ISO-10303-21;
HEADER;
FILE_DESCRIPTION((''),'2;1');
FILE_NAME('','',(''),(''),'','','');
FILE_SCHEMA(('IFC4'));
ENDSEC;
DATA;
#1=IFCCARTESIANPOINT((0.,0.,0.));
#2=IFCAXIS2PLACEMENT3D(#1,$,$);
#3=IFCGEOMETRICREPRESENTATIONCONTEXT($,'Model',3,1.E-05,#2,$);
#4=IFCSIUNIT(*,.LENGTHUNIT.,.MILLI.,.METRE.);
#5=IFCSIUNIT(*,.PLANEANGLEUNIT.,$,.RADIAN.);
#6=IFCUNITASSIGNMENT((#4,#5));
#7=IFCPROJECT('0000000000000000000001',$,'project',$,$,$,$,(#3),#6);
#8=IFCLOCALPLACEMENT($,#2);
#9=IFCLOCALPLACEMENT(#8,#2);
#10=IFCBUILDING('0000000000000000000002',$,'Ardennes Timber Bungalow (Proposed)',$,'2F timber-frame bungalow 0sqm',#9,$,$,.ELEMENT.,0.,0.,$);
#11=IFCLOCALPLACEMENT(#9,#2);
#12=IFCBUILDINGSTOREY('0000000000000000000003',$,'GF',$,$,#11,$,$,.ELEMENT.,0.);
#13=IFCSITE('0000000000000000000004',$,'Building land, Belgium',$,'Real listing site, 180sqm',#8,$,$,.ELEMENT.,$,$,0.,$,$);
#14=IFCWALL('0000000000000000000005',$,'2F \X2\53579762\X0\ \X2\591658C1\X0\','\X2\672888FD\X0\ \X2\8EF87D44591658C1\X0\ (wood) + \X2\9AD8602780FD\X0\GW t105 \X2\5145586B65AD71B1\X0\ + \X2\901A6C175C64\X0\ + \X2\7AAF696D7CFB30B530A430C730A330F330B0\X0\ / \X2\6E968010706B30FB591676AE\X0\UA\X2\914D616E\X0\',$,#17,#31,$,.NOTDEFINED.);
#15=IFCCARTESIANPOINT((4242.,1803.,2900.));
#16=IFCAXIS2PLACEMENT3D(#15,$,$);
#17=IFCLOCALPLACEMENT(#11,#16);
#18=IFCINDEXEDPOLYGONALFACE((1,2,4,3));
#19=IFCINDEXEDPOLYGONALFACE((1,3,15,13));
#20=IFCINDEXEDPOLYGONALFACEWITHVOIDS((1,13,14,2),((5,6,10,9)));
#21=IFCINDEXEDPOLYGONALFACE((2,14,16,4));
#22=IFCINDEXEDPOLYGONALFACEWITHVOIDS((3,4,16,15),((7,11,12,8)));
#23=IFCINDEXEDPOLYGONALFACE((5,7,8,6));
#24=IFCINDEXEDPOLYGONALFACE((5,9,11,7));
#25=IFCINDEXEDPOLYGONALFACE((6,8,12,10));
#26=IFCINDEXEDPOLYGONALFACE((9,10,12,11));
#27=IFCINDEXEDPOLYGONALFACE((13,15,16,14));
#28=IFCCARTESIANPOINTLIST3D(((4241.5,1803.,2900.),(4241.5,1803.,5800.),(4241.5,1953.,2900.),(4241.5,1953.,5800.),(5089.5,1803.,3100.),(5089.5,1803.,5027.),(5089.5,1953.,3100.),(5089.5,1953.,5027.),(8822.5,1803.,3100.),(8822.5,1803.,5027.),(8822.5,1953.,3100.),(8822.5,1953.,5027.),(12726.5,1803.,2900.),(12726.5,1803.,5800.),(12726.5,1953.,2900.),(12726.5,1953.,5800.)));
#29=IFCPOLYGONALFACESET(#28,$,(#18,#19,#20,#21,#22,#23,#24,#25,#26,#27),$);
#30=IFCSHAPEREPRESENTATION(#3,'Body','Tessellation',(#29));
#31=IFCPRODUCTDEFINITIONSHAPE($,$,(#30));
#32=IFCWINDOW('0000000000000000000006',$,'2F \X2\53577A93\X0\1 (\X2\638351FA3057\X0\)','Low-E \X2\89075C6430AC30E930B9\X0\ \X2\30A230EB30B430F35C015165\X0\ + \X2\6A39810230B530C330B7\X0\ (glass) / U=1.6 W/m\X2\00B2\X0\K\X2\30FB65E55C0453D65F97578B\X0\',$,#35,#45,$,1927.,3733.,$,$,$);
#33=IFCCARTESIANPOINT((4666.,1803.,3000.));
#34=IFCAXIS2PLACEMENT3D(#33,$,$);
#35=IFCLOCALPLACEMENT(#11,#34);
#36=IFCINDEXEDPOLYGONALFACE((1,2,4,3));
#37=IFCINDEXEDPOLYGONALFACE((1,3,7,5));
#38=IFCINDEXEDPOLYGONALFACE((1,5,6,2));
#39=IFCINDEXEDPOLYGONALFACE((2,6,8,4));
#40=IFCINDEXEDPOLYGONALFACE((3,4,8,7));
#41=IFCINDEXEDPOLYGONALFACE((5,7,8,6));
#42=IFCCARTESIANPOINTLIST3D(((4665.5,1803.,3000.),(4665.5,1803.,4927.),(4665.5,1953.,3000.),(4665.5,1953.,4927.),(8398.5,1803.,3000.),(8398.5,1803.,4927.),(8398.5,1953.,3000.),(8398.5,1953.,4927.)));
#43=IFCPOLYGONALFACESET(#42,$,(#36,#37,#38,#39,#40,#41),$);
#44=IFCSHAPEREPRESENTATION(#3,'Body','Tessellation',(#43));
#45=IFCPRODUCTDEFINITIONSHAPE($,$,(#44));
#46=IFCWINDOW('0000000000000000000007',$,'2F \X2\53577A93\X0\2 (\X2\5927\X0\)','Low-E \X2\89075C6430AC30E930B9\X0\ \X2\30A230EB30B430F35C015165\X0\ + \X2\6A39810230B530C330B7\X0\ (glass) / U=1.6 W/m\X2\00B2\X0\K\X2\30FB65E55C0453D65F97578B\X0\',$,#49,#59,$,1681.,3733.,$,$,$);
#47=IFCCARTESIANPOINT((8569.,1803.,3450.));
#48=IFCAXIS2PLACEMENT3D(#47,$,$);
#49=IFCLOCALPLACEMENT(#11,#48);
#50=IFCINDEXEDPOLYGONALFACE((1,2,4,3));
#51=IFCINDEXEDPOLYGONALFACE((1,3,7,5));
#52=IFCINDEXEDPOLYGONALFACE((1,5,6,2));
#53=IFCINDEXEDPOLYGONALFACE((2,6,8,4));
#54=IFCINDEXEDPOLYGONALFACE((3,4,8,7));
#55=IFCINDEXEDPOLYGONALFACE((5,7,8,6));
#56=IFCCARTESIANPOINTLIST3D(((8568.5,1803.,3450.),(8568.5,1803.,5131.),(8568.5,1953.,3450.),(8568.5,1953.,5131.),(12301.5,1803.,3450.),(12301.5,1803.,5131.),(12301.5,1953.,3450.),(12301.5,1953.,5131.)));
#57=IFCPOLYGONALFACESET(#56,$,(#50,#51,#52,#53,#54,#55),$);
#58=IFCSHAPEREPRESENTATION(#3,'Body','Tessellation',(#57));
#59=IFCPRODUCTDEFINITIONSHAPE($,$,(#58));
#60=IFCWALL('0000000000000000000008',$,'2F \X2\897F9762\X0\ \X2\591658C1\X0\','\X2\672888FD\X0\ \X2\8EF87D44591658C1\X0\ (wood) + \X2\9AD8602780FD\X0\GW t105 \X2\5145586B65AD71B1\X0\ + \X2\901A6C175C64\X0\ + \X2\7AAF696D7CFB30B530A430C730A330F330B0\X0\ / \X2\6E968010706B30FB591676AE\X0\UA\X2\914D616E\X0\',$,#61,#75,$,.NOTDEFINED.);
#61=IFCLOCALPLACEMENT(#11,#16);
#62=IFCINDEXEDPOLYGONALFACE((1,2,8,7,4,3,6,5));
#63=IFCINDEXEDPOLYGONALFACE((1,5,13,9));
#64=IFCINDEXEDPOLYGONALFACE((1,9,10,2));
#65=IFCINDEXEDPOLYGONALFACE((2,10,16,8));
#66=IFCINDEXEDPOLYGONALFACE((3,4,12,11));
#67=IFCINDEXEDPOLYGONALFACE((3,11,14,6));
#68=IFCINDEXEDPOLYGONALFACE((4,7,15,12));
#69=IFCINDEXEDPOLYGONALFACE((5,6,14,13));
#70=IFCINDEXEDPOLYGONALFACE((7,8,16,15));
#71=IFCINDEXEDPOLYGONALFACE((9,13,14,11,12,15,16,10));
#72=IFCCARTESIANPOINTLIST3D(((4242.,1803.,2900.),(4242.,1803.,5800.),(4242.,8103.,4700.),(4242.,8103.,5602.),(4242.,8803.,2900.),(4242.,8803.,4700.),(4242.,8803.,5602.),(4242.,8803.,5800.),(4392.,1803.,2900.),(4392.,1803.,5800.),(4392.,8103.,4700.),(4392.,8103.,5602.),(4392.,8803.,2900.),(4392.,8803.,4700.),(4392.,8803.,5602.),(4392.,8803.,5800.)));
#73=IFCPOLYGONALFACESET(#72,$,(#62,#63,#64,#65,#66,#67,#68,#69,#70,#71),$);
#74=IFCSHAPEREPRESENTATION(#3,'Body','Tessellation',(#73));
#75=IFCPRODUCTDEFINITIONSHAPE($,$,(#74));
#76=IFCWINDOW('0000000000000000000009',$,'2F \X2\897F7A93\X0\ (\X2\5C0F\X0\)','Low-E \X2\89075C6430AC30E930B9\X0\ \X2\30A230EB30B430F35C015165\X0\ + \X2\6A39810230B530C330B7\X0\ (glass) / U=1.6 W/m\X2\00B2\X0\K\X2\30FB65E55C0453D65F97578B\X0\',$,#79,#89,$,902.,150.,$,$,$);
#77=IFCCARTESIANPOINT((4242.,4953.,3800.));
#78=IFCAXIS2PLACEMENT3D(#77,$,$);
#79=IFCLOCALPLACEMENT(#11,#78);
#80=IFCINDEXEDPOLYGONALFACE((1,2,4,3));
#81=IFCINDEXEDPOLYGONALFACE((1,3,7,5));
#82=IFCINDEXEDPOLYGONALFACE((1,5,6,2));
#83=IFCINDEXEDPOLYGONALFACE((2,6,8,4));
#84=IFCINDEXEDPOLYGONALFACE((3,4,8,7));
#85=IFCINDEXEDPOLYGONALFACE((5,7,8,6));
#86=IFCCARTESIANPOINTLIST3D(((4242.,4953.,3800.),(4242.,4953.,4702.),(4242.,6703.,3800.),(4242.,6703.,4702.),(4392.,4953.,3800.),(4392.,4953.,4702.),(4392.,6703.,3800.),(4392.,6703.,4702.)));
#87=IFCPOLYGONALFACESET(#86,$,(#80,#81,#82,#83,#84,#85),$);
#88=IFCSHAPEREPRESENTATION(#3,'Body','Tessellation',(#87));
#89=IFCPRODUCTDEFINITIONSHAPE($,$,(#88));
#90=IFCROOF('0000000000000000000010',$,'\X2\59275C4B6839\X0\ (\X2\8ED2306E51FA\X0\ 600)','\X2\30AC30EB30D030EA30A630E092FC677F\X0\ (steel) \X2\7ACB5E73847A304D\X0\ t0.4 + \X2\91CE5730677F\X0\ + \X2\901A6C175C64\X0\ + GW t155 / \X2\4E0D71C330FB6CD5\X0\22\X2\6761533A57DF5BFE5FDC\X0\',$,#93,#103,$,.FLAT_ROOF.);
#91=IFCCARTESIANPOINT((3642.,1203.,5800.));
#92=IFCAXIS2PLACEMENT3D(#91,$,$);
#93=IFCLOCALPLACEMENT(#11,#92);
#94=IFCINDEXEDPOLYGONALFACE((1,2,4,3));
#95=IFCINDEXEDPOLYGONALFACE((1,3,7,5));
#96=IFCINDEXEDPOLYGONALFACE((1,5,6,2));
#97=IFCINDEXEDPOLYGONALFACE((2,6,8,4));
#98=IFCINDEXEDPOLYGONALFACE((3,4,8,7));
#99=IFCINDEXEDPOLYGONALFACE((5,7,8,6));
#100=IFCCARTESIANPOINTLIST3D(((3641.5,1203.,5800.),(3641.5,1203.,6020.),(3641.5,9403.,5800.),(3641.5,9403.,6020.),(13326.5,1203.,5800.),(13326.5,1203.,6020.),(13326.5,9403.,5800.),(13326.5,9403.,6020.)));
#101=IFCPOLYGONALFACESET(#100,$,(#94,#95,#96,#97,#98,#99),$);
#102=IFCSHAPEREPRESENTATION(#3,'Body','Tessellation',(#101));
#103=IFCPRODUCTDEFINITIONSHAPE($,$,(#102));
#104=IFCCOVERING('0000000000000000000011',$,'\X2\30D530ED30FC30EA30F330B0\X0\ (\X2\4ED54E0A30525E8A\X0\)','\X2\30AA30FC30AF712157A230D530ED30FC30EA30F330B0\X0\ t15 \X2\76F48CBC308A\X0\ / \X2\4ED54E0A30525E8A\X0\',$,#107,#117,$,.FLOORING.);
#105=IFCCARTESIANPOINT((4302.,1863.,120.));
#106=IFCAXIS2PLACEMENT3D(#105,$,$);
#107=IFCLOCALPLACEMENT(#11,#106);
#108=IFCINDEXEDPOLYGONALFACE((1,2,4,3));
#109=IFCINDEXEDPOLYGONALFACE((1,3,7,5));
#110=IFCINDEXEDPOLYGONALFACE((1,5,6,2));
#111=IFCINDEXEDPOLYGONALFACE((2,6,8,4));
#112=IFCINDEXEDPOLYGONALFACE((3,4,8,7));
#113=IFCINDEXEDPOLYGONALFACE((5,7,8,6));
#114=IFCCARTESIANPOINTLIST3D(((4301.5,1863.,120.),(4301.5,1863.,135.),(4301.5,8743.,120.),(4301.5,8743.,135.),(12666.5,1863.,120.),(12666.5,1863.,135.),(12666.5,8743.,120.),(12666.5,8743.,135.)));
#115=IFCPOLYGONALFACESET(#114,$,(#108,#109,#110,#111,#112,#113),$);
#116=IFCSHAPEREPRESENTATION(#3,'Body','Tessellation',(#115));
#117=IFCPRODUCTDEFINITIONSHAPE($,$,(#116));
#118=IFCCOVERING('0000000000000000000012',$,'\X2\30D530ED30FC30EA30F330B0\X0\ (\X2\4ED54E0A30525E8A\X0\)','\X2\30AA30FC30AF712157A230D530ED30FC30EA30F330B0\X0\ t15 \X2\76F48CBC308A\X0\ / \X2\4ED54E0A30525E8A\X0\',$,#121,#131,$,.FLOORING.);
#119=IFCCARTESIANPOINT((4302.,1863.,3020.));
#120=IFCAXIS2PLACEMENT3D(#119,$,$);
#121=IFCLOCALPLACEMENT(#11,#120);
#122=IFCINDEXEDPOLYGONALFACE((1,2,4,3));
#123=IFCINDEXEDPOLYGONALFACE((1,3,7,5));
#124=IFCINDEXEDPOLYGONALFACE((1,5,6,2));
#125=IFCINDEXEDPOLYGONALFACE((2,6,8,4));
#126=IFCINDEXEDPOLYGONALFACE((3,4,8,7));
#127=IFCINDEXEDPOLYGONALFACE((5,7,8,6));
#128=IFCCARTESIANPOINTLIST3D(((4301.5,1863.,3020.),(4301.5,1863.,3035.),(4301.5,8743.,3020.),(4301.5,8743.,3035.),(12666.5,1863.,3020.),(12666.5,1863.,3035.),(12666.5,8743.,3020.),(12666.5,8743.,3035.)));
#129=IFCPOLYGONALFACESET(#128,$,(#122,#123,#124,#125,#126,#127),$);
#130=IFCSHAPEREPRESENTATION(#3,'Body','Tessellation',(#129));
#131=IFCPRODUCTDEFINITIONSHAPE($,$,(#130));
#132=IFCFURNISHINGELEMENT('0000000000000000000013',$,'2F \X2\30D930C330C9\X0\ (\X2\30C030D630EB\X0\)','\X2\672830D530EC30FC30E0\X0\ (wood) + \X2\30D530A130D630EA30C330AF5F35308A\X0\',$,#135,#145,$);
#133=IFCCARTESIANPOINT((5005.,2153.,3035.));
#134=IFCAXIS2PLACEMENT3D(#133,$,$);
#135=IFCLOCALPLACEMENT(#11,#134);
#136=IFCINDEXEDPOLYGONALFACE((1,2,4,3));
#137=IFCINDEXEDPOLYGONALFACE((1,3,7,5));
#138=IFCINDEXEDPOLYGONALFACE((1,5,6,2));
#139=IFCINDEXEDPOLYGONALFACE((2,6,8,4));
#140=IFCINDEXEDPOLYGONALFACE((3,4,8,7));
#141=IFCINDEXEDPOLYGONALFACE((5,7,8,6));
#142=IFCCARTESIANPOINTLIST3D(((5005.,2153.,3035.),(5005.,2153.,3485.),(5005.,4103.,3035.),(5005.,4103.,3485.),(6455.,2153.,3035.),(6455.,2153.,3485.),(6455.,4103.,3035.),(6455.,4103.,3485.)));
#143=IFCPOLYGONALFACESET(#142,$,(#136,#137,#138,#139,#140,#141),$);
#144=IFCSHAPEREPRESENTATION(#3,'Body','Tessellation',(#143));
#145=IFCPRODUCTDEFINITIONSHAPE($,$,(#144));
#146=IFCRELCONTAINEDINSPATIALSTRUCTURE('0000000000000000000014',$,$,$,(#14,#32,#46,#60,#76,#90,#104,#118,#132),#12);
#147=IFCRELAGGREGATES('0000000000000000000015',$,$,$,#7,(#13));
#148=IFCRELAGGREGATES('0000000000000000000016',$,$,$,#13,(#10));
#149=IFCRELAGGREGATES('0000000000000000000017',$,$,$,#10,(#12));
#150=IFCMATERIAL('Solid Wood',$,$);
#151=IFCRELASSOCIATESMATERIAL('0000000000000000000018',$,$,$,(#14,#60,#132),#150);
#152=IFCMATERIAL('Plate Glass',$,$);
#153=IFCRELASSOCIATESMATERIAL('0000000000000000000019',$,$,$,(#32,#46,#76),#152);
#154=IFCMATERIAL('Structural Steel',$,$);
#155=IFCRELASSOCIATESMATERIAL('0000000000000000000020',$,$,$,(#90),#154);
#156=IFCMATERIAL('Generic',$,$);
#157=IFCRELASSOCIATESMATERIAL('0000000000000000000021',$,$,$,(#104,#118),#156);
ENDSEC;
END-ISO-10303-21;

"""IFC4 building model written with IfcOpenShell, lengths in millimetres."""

from ifc_helpers import new_model, si_unit, frame, frame_2d, origin, place, context, project, spatial, rectangle, extrude, material, element, fill, save


model = new_model("IFC4")

# Units and contexts
model_context = context("Model", 3, precision=1e-05, world=origin())
ifc_project = project(units=[si_unit("LENGTHUNIT", "METRE", prefix="MILLI"), si_unit("PLANEANGLEUNIT", "RADIAN")], contexts=[model_context])

# Site, building, storey
site_placement = place(None, origin())
site = spatial("IfcSite", under=ifc_project, at=site_placement, Name="Building land, Belgium", ObjectType="Real listing site, 180sqm", CompositionType="ELEMENT", RefElevation=0.0)
building_placement = place(site_placement, origin())
building = spatial("IfcBuilding", under=site, at=building_placement, Name="Ardennes Timber Bungalow (Proposed)", ObjectType="2F timber-frame bungalow 0sqm", CompositionType="ELEMENT", ElevationOfRefHeight=0.0, ElevationOfTerrain=0.0)
storey_placement = place(building_placement, origin())
storey = spatial("IfcBuildingStorey", under=building, at=storey_placement, Name="GF", CompositionType="ELEMENT", Elevation=0.0)

# Shared definitions
ifc_material_1 = material(Name="Solid Wood")

# Shared definitions
ifc_material_2 = material(Name="Plate Glass")

# Wall, openings, windows
wall_1_placement = place(storey_placement, frame((4242.0, 1803.0, 2900.0)))
wall_1 = element("IfcWall", 1, at=wall_1_placement, inside=storey, material=ifc_material_1, Name="2F 南面 外壁", Description="木製 軸組外壁 (wood) + 高性能GW t105 充填断熱 + 通気層 + 窯業系サイディング / 準耐火・外皮UA配慮", PredefinedType="NOTDEFINED", context=model_context, shape_type="SweptSolid", body=[
    extrude(rectangle(XDim=8485.0, YDim=150.0, at=frame_2d((4242.0, 75.0))), frame((4242.0, 1803.0, 2900.0)), (0.0, 0.0, 1.0), 2900.0),
])
opening_1_placement = place(storey_placement, frame((4666.0, 1803.0, 3000.0)))
opening_1 = element("IfcOpeningElement", 2, at=opening_1_placement, cuts=wall_1, PredefinedType="NOTDEFINED", context=model_context, shape_type="SweptSolid", body=[
    extrude(rectangle(XDim=3733.0, YDim=150.0, at=frame_2d((1866.0, 75.0))), frame((4666.0, 1803.0, 3000.0)), (0.0, 0.0, 1.0), 1927.0),
])
opening_2_placement = place(storey_placement, frame((8569.0, 1803.0, 3450.0)))
opening_2 = element("IfcOpeningElement", 3, at=opening_2_placement, cuts=wall_1, PredefinedType="NOTDEFINED", context=model_context, shape_type="SweptSolid", body=[
    extrude(rectangle(XDim=3733.0, YDim=150.0, at=frame_2d((1866.0, 75.0))), frame((8569.0, 1803.0, 3450.0)), (0.0, 0.0, 1.0), 1681.0),
])
window_1_placement = place(storey_placement, frame((4666.0, 1803.0, 3000.0)))
window_1 = element("IfcWindow", 4, at=window_1_placement, inside=storey, material=ifc_material_2, Name="2F 南窓1 (掃出し)", Description="Low-E 複層ガラス アルゴン封入 + 樹脂サッシ (glass) / U=1.6 W/m²K・日射取得型", OverallHeight=1927.0, OverallWidth=3733.0, context=model_context, shape_type="SweptSolid", body=[
    extrude(rectangle(XDim=3733.0, YDim=150.0, at=frame_2d((1866.0, 75.0))), frame((4666.0, 1803.0, 3000.0)), (0.0, 0.0, 1.0), 1927.0),
])
fill(opening_1, window_1)
window_2_placement = place(storey_placement, frame((8569.0, 1803.0, 3450.0)))
window_2 = element("IfcWindow", 5, at=window_2_placement, inside=storey, material=ifc_material_2, Name="2F 南窓2 (大)", Description="Low-E 複層ガラス アルゴン封入 + 樹脂サッシ (glass) / U=1.6 W/m²K・日射取得型", OverallHeight=1681.0, OverallWidth=3733.0, context=model_context, shape_type="SweptSolid", body=[
    extrude(rectangle(XDim=3733.0, YDim=150.0, at=frame_2d((1866.0, 75.0))), frame((8569.0, 1803.0, 3450.0)), (0.0, 0.0, 1.0), 1681.0),
])
fill(opening_2, window_2)

# Wall, opening, window
wall_2_placement = place(storey_placement, frame((4242.0, 1803.0, 2900.0)))
wall_2 = element("IfcWall", 6, at=wall_2_placement, inside=storey, material=ifc_material_1, Name="2F 西面 外壁", Description="木製 軸組外壁 (wood) + 高性能GW t105 充填断熱 + 通気層 + 窯業系サイディング / 準耐火・外皮UA配慮", PredefinedType="NOTDEFINED", context=model_context, shape_type="SweptSolid", body=[
    extrude(rectangle(XDim=150.0, YDim=7000.0, at=frame_2d((75.0, 3500.0))), frame((4242.0, 1803.0, 2900.0)), (0.0, 0.0, 1.0), 2900.0),
])
opening_3_placement = place(storey_placement, frame((4242.0, 4953.0, 3800.0)))
opening_3 = element("IfcOpeningElement", 7, at=opening_3_placement, cuts=wall_2, PredefinedType="NOTDEFINED", context=model_context, shape_type="SweptSolid", body=[
    extrude(rectangle(XDim=150.0, YDim=1750.0, at=frame_2d((75.0, 875.0))), frame((4242.0, 4953.0, 3800.0)), (0.0, 0.0, 1.0), 902.0),
])
window_3_placement = place(storey_placement, frame((4242.0, 4953.0, 3800.0)))
window_3 = element("IfcWindow", 8, at=window_3_placement, inside=storey, material=ifc_material_2, Name="2F 西窓 (小)", Description="Low-E 複層ガラス アルゴン封入 + 樹脂サッシ (glass) / U=1.6 W/m²K・日射取得型", OverallHeight=902.0, OverallWidth=150.0, context=model_context, shape_type="SweptSolid", body=[
    extrude(rectangle(XDim=150.0, YDim=1750.0, at=frame_2d((75.0, 875.0))), frame((4242.0, 4953.0, 3800.0)), (0.0, 0.0, 1.0), 902.0),
])
fill(opening_3, window_3)

# Roof
ifc_material_3 = material(Name="Structural Steel")
roof_placement = place(storey_placement, frame((3642.0, 1203.0, 5800.0)))
element("IfcRoof", 9, at=roof_placement, inside=storey, material=ifc_material_3, Name="大屋根 (軒の出 600)", Description="ガルバリウム鋼板 (steel) 立平葺き t0.4 + 野地板 + 通気層 + GW t155 / 不燃・法22条区域対応", PredefinedType="FLAT_ROOF", context=model_context, shape_type="SweptSolid", body=[
    extrude(rectangle(XDim=9685.0, YDim=8200.0, at=frame_2d((4842.0, 4100.0))), frame((3642.0, 1203.0, 5800.0)), (0.0, 0.0, 1.0), 220.0),
])

# Coverings
ifc_material_4 = material(Name="Generic")
covering_1_placement = place(storey_placement, frame((4302.0, 1863.0, 120.0)))
element("IfcCovering", 10, at=covering_1_placement, inside=storey, material=ifc_material_4, Name="フローリング (仕上げ床)", Description="オーク無垢フローリング t15 直貼り / 仕上げ床", PredefinedType="FLOORING", context=model_context, shape_type="SweptSolid", body=[
    extrude(rectangle(XDim=8365.0, YDim=6880.0, at=frame_2d((4182.0, 3440.0))), frame((4302.0, 1863.0, 120.0)), (0.0, 0.0, 1.0), 15.0),
])
covering_2_placement = place(storey_placement, frame((4302.0, 1863.0, 3020.0)))
element("IfcCovering", 11, at=covering_2_placement, inside=storey, material=ifc_material_4, Name="フローリング (仕上げ床)", Description="オーク無垢フローリング t15 直貼り / 仕上げ床", PredefinedType="FLOORING", context=model_context, shape_type="SweptSolid", body=[
    extrude(rectangle(XDim=8365.0, YDim=6880.0, at=frame_2d((4182.0, 3440.0))), frame((4302.0, 1863.0, 3020.0)), (0.0, 0.0, 1.0), 15.0),
])

# Furnishing element
furnishing_placement = place(storey_placement, frame((5005.0, 2153.0, 3035.0)))
element("IfcFurnishingElement", 12, at=furnishing_placement, inside=storey, material=ifc_material_1, Name="2F ベッド (ダブル)", Description="木フレーム (wood) + ファブリック張り", context=model_context, shape_type="SweptSolid", body=[
    extrude(rectangle(XDim=1450.0, YDim=1950.0, at=frame_2d((725.0, 975.0))), frame((5005.0, 2153.0, 3035.0)), (0.0, 0.0, 1.0), 450.0),
])

save(model, "model.ifc")
